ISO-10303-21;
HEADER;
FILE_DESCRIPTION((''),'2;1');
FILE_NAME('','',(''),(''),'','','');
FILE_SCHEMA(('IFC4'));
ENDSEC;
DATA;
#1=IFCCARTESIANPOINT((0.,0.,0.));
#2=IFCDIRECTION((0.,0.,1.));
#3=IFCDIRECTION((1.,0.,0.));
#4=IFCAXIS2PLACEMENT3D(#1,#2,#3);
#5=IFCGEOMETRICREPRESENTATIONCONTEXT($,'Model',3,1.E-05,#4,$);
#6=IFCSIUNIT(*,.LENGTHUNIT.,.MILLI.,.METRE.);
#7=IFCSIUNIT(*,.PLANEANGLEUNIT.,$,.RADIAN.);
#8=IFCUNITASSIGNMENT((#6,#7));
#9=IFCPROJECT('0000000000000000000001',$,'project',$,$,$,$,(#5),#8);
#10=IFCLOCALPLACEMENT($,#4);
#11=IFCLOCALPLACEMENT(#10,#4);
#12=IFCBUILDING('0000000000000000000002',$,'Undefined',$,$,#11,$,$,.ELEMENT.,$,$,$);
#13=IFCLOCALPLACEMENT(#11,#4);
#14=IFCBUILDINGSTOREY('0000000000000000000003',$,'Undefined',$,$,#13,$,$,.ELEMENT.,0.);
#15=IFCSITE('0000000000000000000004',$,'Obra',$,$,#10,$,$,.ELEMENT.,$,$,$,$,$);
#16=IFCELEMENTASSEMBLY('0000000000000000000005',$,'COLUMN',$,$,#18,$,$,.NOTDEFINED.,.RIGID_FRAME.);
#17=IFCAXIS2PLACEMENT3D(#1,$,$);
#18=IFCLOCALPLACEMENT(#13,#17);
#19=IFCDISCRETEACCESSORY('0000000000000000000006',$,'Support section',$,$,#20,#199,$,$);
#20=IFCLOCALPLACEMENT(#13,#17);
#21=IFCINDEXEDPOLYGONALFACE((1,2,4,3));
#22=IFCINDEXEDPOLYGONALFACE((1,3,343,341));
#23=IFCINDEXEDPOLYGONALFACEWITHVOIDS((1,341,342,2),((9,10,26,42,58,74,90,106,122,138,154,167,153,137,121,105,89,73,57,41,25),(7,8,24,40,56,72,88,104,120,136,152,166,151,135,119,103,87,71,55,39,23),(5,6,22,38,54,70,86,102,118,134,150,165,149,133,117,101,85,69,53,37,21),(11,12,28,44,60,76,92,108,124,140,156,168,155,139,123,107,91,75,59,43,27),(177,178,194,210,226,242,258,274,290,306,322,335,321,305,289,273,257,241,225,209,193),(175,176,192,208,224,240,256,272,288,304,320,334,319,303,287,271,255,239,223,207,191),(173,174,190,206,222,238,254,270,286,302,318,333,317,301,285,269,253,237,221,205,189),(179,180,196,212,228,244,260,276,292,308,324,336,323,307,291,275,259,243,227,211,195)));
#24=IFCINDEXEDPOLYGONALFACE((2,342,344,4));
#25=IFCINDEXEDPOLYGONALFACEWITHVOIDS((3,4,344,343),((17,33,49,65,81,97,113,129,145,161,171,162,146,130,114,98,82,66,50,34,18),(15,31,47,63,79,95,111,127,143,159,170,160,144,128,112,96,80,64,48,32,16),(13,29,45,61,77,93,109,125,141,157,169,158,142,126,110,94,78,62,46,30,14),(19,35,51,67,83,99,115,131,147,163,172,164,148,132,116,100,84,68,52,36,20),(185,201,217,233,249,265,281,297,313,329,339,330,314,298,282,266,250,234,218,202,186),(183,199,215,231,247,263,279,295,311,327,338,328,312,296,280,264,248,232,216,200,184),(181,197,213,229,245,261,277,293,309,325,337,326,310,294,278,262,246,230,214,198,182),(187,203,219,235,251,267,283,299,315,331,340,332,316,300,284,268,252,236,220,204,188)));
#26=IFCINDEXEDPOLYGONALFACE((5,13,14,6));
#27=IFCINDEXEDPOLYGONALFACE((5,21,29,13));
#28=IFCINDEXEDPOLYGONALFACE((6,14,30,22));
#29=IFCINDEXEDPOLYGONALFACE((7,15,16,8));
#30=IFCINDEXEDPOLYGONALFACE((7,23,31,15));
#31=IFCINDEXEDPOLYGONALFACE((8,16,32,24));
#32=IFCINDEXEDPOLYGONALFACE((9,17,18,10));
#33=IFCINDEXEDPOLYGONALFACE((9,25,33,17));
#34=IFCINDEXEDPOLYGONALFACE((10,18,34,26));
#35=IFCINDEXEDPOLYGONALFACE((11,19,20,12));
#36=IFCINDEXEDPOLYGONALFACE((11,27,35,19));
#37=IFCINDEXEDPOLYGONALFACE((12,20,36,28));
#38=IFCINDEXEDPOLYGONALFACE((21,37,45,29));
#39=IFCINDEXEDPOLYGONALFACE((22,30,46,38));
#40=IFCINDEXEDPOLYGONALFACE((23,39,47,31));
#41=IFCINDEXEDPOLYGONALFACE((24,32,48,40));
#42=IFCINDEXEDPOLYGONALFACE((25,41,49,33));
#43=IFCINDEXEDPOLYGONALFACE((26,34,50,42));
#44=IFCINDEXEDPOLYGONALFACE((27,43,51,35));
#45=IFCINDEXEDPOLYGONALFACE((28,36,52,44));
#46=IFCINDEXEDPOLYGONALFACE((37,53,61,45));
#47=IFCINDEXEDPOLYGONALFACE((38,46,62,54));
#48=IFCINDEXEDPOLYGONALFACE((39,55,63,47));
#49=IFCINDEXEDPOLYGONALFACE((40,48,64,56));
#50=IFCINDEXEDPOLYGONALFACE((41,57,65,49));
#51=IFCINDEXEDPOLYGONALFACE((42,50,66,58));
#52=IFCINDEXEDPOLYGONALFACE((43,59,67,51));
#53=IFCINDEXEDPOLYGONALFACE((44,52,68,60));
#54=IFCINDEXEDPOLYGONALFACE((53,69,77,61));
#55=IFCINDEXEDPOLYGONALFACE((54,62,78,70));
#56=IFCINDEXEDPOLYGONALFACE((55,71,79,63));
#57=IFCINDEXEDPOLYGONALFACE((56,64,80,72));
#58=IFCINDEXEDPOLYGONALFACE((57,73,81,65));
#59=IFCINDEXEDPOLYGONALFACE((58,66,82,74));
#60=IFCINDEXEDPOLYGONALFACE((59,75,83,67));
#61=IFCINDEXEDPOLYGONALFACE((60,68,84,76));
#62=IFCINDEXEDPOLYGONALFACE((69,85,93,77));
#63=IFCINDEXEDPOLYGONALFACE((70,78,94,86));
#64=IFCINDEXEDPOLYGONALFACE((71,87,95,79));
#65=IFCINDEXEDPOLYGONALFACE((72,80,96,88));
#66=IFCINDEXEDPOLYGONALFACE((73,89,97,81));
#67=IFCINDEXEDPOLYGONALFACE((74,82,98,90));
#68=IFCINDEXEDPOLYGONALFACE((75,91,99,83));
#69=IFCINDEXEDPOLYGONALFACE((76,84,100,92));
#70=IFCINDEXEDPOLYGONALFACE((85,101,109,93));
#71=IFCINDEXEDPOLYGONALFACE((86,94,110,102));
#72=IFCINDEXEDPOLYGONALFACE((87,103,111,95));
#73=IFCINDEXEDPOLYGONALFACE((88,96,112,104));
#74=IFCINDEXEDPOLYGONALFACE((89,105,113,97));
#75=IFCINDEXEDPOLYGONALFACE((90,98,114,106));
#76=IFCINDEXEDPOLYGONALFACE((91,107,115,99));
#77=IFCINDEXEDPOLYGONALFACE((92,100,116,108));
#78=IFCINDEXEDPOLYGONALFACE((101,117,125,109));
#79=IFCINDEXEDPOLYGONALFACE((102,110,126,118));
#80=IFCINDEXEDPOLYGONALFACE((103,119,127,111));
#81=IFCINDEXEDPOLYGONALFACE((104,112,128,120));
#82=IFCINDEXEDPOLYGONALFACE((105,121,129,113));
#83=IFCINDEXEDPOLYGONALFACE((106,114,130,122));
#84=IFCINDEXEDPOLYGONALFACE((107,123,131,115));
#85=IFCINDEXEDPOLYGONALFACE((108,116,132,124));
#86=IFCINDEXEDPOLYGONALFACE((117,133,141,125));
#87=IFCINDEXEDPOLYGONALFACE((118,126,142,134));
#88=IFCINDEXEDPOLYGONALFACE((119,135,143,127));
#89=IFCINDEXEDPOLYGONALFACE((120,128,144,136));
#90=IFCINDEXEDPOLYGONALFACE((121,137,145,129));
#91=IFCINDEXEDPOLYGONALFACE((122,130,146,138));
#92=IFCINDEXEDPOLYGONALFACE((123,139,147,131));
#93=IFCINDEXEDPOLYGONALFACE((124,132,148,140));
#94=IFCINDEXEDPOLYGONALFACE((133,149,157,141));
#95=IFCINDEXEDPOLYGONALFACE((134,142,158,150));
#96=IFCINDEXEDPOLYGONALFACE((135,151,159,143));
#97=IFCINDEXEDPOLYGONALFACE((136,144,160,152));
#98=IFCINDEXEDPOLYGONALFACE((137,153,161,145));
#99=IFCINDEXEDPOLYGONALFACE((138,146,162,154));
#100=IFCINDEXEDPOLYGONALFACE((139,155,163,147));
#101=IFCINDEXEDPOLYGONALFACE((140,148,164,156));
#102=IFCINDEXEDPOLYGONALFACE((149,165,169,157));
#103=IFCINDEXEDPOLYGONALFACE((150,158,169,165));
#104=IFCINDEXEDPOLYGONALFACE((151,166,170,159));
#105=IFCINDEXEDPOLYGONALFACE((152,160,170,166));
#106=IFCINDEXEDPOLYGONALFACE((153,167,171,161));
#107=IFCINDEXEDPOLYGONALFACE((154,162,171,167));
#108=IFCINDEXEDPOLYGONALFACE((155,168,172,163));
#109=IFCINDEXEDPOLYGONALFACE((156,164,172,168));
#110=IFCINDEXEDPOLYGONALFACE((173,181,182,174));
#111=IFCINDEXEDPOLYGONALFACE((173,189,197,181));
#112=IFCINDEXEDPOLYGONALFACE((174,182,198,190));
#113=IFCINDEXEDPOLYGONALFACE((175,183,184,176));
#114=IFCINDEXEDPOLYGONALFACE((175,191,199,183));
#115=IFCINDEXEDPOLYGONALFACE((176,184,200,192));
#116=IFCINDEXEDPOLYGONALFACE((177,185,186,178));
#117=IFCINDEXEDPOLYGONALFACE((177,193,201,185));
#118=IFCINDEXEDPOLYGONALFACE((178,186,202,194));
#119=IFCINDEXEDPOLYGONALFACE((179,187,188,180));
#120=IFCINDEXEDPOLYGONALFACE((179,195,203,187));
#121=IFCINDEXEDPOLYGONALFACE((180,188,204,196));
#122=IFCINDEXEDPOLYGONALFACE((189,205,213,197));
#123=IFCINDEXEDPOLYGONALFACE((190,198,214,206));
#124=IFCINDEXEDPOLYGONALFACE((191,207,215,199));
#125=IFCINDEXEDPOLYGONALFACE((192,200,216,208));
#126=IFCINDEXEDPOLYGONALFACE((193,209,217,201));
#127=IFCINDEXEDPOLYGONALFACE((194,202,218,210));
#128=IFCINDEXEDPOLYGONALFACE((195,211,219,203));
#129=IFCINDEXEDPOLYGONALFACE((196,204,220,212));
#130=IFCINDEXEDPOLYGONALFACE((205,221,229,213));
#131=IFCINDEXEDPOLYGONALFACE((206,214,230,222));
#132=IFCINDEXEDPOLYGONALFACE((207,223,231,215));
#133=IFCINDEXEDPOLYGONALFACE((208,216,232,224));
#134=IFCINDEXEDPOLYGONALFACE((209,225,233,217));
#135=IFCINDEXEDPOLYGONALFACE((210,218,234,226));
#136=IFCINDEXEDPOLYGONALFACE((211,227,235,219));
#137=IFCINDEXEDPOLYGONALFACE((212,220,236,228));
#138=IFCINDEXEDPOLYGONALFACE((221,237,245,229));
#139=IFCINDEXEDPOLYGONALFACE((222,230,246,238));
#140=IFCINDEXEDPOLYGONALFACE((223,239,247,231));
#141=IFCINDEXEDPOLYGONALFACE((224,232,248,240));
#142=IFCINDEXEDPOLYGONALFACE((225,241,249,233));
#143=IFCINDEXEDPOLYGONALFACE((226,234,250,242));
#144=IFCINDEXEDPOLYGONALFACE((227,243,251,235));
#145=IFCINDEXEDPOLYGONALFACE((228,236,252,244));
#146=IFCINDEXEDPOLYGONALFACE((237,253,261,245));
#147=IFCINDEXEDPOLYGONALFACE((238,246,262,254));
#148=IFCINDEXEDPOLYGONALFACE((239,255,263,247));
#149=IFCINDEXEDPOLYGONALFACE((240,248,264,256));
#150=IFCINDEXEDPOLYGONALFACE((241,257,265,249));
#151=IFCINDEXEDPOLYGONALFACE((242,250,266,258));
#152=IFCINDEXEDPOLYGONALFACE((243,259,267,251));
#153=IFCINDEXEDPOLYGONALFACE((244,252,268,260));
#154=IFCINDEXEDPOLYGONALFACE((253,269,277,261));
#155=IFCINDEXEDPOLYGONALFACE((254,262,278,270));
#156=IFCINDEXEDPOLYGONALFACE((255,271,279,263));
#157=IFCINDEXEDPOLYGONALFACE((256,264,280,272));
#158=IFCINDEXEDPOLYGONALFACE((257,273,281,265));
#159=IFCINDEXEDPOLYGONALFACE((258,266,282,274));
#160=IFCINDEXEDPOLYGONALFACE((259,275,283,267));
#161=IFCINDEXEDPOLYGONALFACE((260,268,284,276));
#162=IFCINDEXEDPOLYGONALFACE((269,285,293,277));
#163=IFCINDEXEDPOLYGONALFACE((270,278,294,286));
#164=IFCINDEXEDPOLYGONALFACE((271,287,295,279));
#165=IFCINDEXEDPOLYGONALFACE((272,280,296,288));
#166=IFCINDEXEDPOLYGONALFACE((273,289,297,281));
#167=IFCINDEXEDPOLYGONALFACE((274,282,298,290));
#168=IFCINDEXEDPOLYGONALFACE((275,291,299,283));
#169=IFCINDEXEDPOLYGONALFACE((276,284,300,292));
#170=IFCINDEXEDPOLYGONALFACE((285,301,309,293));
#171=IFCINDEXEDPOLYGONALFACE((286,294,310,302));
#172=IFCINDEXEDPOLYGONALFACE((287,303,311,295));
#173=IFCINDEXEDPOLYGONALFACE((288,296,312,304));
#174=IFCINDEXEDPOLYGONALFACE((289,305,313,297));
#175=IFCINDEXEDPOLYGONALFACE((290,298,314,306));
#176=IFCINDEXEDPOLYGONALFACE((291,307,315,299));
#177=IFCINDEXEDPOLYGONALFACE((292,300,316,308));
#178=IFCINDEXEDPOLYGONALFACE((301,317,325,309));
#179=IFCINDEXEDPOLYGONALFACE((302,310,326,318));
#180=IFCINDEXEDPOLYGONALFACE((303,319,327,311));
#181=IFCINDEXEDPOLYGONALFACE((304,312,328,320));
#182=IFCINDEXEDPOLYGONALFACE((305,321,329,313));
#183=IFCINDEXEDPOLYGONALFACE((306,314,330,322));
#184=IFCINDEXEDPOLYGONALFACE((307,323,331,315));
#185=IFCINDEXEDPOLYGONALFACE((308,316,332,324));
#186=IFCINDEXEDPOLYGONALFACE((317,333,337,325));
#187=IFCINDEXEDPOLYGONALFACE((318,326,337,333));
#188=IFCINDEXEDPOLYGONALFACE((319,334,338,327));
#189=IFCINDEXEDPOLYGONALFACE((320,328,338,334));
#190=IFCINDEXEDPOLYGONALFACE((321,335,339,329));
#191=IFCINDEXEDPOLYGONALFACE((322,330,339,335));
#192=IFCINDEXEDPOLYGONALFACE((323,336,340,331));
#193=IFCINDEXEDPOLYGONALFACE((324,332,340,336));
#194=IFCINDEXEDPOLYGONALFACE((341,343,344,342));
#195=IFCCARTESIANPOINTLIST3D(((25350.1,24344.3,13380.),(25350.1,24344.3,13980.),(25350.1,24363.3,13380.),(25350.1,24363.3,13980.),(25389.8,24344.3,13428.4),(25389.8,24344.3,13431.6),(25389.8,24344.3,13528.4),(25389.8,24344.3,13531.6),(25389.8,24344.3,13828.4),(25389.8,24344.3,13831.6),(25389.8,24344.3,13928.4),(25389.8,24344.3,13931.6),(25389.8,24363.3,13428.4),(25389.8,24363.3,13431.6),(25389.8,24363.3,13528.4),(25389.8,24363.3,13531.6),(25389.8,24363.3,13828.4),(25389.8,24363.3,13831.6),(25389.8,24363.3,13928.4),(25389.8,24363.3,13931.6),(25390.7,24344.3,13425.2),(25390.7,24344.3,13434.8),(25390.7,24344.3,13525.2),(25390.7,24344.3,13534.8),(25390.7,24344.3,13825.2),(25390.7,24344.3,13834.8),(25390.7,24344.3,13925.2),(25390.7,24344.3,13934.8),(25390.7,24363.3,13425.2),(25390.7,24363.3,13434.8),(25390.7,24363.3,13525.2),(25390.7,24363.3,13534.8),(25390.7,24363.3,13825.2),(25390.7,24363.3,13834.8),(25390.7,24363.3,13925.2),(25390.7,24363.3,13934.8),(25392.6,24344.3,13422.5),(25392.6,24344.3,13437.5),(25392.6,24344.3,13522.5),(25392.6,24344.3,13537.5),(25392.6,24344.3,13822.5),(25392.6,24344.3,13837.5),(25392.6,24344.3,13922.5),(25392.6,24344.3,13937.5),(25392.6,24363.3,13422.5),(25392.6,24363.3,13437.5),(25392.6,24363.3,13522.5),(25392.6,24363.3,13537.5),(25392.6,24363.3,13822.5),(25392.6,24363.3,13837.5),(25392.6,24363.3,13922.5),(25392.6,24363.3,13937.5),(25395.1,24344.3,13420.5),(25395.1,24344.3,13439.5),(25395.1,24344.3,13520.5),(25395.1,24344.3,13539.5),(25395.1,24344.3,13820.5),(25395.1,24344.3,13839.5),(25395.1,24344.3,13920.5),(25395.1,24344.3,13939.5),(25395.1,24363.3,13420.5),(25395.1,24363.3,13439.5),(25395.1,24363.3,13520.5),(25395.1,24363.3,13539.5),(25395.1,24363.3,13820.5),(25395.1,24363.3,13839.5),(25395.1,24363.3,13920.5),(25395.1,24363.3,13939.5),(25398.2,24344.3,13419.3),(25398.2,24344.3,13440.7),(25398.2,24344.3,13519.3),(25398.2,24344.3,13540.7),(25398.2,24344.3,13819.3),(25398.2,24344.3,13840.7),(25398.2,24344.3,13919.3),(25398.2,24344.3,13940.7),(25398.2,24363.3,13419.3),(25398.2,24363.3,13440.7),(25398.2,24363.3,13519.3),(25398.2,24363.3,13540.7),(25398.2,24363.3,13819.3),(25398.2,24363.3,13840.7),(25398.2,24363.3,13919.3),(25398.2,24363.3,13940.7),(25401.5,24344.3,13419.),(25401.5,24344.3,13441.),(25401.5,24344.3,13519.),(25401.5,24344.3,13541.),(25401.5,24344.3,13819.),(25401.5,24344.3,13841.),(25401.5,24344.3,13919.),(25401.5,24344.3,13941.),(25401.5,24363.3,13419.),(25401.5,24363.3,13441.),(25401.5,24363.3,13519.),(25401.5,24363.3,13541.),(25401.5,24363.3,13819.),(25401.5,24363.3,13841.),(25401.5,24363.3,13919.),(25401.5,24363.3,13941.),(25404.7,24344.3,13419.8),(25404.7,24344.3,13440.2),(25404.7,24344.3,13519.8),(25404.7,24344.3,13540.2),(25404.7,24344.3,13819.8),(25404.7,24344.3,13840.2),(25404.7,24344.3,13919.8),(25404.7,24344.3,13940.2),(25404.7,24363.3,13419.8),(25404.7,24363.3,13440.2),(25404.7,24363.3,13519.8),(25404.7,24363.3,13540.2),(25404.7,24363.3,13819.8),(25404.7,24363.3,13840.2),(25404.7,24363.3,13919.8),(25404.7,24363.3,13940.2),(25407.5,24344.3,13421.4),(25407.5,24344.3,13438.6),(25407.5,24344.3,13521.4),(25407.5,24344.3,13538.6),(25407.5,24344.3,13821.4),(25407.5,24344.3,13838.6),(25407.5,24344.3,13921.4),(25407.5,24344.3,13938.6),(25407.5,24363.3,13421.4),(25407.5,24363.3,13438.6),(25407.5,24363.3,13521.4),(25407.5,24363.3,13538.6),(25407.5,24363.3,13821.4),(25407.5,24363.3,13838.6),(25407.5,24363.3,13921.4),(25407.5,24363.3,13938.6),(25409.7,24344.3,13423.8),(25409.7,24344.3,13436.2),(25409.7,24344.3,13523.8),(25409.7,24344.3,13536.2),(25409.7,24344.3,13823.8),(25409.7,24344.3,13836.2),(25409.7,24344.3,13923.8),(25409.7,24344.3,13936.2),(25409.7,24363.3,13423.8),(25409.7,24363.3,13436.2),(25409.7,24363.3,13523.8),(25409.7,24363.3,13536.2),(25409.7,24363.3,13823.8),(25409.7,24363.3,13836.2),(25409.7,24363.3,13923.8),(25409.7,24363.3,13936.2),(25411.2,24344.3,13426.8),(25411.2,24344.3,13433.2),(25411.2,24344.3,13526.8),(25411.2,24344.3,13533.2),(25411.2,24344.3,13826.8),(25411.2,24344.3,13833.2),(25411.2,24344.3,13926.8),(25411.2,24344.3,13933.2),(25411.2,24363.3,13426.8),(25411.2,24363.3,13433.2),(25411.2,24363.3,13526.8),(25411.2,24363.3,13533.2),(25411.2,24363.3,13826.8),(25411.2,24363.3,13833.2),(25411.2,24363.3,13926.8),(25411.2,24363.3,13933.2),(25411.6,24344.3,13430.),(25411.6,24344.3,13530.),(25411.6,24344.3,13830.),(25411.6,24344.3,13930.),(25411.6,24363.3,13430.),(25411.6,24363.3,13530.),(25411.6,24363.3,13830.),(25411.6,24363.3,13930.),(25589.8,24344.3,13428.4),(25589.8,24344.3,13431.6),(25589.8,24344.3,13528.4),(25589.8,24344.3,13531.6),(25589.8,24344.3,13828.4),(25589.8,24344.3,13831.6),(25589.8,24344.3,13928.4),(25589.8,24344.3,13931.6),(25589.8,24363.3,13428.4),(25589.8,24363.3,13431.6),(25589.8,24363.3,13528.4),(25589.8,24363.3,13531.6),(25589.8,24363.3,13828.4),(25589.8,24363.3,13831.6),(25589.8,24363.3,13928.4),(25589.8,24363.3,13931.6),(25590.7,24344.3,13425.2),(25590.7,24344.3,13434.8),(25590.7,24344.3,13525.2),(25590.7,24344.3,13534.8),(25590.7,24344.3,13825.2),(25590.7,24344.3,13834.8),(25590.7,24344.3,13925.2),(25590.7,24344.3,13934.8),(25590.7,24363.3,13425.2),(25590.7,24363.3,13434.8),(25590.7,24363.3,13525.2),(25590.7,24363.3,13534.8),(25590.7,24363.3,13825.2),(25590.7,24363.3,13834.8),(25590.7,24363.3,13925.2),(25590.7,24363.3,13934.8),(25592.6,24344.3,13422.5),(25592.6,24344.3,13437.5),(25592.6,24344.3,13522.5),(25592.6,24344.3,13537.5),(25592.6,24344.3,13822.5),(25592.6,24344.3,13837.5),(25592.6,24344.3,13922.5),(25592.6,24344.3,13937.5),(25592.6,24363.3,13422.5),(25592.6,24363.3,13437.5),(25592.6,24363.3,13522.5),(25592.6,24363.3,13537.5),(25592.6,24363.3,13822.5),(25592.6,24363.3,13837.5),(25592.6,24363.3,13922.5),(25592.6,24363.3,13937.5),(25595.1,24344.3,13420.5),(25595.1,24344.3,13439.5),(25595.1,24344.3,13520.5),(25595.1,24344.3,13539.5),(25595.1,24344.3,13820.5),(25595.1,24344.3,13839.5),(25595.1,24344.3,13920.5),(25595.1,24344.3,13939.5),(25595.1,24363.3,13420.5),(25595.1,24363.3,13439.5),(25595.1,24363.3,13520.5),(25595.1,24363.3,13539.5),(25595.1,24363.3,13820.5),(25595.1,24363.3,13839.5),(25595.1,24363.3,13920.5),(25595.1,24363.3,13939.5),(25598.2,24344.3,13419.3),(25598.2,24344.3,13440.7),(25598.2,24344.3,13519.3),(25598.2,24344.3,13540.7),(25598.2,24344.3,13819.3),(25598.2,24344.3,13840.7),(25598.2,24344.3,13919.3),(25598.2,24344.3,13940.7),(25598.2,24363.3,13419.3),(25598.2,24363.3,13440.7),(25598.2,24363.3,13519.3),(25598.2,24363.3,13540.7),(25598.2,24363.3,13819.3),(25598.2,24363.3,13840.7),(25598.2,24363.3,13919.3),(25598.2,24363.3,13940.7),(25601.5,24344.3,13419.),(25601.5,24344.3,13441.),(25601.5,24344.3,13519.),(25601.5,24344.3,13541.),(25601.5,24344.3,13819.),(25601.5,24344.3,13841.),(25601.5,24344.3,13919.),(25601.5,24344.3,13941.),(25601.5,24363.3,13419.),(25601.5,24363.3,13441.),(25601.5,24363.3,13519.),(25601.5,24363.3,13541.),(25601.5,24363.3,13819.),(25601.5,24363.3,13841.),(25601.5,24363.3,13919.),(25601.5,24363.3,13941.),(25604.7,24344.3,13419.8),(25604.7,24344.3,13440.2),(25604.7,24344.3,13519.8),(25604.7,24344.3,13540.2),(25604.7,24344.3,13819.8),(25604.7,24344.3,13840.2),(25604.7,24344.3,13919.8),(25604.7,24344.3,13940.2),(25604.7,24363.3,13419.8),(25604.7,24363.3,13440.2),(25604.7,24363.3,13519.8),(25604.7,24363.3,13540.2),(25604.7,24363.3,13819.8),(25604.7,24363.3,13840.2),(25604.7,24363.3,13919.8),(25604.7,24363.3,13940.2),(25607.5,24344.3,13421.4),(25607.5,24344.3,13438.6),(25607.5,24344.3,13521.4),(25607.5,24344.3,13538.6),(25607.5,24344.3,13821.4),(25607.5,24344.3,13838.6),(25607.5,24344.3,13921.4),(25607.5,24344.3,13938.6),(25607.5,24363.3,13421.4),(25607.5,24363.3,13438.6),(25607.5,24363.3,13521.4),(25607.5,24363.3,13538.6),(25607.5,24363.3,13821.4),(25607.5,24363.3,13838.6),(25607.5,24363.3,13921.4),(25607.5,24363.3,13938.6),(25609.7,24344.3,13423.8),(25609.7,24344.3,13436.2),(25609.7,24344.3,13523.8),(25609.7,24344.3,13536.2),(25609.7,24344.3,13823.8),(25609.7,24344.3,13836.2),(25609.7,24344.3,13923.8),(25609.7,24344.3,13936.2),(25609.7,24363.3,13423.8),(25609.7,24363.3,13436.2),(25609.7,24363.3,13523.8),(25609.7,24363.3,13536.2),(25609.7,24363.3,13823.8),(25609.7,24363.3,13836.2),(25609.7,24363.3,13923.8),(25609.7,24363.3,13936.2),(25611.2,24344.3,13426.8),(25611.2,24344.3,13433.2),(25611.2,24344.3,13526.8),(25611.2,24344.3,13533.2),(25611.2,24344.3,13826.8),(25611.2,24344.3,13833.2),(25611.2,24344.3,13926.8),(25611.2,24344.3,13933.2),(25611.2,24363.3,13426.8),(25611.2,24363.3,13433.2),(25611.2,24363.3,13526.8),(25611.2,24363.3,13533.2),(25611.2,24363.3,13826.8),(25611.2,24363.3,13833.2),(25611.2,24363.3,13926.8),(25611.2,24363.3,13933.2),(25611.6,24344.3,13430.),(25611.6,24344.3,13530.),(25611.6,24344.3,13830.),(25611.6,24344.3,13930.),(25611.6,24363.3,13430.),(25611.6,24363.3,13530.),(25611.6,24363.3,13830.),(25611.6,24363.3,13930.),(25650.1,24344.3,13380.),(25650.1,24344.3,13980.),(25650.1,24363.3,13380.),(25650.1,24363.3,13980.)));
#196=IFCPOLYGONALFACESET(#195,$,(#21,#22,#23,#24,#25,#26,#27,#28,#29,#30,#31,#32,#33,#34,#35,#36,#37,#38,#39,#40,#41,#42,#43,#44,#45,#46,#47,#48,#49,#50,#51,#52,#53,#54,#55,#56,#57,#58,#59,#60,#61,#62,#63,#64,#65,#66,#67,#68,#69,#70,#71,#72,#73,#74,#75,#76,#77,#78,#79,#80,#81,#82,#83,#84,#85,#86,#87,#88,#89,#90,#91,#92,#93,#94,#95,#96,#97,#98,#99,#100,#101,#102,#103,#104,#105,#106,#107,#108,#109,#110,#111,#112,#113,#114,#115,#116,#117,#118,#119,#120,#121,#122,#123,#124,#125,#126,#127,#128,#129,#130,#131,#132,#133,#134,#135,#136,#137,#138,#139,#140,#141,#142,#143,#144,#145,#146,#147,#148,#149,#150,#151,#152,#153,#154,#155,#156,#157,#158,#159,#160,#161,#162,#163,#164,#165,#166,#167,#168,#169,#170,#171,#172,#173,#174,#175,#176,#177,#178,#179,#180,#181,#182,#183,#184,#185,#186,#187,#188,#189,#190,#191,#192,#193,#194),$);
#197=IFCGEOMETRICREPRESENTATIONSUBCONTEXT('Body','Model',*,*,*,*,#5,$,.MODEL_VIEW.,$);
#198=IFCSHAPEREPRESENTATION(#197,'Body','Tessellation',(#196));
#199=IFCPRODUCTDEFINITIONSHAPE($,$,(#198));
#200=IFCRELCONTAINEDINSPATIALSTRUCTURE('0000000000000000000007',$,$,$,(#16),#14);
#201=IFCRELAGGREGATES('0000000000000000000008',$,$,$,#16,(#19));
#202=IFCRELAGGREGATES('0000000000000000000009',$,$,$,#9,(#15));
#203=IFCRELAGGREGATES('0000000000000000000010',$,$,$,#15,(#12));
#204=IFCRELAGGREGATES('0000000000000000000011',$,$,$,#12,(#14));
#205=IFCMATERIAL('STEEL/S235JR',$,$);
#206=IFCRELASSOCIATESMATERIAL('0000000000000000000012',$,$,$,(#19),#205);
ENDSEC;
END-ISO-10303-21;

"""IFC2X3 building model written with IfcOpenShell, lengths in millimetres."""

from ifc_helpers import new_model, si_unit, frame, origin_with_axes, origin_2d_with_axis, place, context, subcontext, project, spatial, rectangle, circle, extrude, source, transform, mapped, material, element, aggregate, save


model = new_model("IFC2X3")

# Units and contexts
model_context = context("Model", 3, precision=1e-05, world=origin_with_axes())
body_context = subcontext(model_context, "Body", "Model", "MODEL_VIEW")
ifc_project = project(units=[si_unit("LENGTHUNIT", "METRE", prefix="MILLI"), si_unit("PLANEANGLEUNIT", "RADIAN")], contexts=[model_context])

# Site, building, storey
site_placement = place(None, origin_with_axes())
site = spatial("IfcSite", under=ifc_project, at=site_placement, Name="Obra", CompositionType="ELEMENT")
building_placement = place(site_placement, origin_with_axes())
building = spatial("IfcBuilding", under=site, at=building_placement, Name="Undefined", CompositionType="ELEMENT")
storey_placement = place(building_placement, origin_with_axes())
storey = spatial("IfcBuildingStorey", under=building, at=storey_placement, Name="Undefined", CompositionType="ELEMENT", Elevation=0.0)

# Element assembly
assembly_1_placement = place(storey_placement, origin_with_axes())
assembly_1 = element("IfcElementAssembly", 1, at=assembly_1_placement, inside=storey, Name="COLUMN", AssemblyPlace="NOTDEFINED", PredefinedType="RIGID_FRAME")
ifc_material_1 = material(Name="STEEL/S235JR")

# Discrete accessory, opening
discrete_accessory_1_placement = place(assembly_1_placement, frame((25650.1, 24353.8, 13680.0), z_axis=(0.0, 0.0, -1.0), x_axis=(-1.0, 0.0, 0.0)))
discrete_accessory_1 = element("IfcDiscreteAccessory", 2, at=discrete_accessory_1_placement, material=ifc_material_1, Name="Support section", context=body_context, shape_type="SweptSolid", body=[
    extrude(rectangle(XDim=19.0, YDim=600.0, at=origin_2d_with_axis()), frame((300.0, 0.0, 0.0), z_axis=(-1.0, 0.0, 0.0), x_axis=(0.0, -1.0, 0.0)), (0.0, 0.0, 1.0), 300.0),
])
shared_shape_1 = source(origin_with_axes(), body_context, "Body", "SweptSolid", [
    extrude(circle(Radius=11.0, at=origin_2d_with_axis()), frame((0.0, -19.1, 0.0), z_axis=(0.0, 1.0, 0.0), x_axis=(1.0, 0.0, 0.0)), (0.0, 0.0, 1.0), 19.2),
])
opening_1_placement = place(assembly_1_placement, frame((25350.6, 24344.3, 13680.0), z_axis=(0.0, 0.0, -1.0), x_axis=(1.0, 0.0, 0.0)))
element("IfcOpeningElement", 3, at=opening_1_placement, cuts=discrete_accessory_1, ObjectType="Opening", context=body_context, shape_type="MappedRepresentation", body=[
    mapped(shared_shape_1, transform((50.1, 0.0, -250.0))),
    mapped(shared_shape_1, transform((50.1, 0.0, -150.0))),
    mapped(shared_shape_1, transform((50.1, 0.0, 150.0))),
    mapped(shared_shape_1, transform((50.1, 0.0, 250.0))),
    mapped(shared_shape_1, transform((250.1, 0.0, -250.0))),
    mapped(shared_shape_1, transform((250.1, 0.0, -150.0))),
    mapped(shared_shape_1, transform((250.1, 0.0, 150.0))),
    mapped(shared_shape_1, transform((250.1, 0.0, 250.0))),
])
aggregate(assembly_1, [discrete_accessory_1])

save(model, "model.ifc")
